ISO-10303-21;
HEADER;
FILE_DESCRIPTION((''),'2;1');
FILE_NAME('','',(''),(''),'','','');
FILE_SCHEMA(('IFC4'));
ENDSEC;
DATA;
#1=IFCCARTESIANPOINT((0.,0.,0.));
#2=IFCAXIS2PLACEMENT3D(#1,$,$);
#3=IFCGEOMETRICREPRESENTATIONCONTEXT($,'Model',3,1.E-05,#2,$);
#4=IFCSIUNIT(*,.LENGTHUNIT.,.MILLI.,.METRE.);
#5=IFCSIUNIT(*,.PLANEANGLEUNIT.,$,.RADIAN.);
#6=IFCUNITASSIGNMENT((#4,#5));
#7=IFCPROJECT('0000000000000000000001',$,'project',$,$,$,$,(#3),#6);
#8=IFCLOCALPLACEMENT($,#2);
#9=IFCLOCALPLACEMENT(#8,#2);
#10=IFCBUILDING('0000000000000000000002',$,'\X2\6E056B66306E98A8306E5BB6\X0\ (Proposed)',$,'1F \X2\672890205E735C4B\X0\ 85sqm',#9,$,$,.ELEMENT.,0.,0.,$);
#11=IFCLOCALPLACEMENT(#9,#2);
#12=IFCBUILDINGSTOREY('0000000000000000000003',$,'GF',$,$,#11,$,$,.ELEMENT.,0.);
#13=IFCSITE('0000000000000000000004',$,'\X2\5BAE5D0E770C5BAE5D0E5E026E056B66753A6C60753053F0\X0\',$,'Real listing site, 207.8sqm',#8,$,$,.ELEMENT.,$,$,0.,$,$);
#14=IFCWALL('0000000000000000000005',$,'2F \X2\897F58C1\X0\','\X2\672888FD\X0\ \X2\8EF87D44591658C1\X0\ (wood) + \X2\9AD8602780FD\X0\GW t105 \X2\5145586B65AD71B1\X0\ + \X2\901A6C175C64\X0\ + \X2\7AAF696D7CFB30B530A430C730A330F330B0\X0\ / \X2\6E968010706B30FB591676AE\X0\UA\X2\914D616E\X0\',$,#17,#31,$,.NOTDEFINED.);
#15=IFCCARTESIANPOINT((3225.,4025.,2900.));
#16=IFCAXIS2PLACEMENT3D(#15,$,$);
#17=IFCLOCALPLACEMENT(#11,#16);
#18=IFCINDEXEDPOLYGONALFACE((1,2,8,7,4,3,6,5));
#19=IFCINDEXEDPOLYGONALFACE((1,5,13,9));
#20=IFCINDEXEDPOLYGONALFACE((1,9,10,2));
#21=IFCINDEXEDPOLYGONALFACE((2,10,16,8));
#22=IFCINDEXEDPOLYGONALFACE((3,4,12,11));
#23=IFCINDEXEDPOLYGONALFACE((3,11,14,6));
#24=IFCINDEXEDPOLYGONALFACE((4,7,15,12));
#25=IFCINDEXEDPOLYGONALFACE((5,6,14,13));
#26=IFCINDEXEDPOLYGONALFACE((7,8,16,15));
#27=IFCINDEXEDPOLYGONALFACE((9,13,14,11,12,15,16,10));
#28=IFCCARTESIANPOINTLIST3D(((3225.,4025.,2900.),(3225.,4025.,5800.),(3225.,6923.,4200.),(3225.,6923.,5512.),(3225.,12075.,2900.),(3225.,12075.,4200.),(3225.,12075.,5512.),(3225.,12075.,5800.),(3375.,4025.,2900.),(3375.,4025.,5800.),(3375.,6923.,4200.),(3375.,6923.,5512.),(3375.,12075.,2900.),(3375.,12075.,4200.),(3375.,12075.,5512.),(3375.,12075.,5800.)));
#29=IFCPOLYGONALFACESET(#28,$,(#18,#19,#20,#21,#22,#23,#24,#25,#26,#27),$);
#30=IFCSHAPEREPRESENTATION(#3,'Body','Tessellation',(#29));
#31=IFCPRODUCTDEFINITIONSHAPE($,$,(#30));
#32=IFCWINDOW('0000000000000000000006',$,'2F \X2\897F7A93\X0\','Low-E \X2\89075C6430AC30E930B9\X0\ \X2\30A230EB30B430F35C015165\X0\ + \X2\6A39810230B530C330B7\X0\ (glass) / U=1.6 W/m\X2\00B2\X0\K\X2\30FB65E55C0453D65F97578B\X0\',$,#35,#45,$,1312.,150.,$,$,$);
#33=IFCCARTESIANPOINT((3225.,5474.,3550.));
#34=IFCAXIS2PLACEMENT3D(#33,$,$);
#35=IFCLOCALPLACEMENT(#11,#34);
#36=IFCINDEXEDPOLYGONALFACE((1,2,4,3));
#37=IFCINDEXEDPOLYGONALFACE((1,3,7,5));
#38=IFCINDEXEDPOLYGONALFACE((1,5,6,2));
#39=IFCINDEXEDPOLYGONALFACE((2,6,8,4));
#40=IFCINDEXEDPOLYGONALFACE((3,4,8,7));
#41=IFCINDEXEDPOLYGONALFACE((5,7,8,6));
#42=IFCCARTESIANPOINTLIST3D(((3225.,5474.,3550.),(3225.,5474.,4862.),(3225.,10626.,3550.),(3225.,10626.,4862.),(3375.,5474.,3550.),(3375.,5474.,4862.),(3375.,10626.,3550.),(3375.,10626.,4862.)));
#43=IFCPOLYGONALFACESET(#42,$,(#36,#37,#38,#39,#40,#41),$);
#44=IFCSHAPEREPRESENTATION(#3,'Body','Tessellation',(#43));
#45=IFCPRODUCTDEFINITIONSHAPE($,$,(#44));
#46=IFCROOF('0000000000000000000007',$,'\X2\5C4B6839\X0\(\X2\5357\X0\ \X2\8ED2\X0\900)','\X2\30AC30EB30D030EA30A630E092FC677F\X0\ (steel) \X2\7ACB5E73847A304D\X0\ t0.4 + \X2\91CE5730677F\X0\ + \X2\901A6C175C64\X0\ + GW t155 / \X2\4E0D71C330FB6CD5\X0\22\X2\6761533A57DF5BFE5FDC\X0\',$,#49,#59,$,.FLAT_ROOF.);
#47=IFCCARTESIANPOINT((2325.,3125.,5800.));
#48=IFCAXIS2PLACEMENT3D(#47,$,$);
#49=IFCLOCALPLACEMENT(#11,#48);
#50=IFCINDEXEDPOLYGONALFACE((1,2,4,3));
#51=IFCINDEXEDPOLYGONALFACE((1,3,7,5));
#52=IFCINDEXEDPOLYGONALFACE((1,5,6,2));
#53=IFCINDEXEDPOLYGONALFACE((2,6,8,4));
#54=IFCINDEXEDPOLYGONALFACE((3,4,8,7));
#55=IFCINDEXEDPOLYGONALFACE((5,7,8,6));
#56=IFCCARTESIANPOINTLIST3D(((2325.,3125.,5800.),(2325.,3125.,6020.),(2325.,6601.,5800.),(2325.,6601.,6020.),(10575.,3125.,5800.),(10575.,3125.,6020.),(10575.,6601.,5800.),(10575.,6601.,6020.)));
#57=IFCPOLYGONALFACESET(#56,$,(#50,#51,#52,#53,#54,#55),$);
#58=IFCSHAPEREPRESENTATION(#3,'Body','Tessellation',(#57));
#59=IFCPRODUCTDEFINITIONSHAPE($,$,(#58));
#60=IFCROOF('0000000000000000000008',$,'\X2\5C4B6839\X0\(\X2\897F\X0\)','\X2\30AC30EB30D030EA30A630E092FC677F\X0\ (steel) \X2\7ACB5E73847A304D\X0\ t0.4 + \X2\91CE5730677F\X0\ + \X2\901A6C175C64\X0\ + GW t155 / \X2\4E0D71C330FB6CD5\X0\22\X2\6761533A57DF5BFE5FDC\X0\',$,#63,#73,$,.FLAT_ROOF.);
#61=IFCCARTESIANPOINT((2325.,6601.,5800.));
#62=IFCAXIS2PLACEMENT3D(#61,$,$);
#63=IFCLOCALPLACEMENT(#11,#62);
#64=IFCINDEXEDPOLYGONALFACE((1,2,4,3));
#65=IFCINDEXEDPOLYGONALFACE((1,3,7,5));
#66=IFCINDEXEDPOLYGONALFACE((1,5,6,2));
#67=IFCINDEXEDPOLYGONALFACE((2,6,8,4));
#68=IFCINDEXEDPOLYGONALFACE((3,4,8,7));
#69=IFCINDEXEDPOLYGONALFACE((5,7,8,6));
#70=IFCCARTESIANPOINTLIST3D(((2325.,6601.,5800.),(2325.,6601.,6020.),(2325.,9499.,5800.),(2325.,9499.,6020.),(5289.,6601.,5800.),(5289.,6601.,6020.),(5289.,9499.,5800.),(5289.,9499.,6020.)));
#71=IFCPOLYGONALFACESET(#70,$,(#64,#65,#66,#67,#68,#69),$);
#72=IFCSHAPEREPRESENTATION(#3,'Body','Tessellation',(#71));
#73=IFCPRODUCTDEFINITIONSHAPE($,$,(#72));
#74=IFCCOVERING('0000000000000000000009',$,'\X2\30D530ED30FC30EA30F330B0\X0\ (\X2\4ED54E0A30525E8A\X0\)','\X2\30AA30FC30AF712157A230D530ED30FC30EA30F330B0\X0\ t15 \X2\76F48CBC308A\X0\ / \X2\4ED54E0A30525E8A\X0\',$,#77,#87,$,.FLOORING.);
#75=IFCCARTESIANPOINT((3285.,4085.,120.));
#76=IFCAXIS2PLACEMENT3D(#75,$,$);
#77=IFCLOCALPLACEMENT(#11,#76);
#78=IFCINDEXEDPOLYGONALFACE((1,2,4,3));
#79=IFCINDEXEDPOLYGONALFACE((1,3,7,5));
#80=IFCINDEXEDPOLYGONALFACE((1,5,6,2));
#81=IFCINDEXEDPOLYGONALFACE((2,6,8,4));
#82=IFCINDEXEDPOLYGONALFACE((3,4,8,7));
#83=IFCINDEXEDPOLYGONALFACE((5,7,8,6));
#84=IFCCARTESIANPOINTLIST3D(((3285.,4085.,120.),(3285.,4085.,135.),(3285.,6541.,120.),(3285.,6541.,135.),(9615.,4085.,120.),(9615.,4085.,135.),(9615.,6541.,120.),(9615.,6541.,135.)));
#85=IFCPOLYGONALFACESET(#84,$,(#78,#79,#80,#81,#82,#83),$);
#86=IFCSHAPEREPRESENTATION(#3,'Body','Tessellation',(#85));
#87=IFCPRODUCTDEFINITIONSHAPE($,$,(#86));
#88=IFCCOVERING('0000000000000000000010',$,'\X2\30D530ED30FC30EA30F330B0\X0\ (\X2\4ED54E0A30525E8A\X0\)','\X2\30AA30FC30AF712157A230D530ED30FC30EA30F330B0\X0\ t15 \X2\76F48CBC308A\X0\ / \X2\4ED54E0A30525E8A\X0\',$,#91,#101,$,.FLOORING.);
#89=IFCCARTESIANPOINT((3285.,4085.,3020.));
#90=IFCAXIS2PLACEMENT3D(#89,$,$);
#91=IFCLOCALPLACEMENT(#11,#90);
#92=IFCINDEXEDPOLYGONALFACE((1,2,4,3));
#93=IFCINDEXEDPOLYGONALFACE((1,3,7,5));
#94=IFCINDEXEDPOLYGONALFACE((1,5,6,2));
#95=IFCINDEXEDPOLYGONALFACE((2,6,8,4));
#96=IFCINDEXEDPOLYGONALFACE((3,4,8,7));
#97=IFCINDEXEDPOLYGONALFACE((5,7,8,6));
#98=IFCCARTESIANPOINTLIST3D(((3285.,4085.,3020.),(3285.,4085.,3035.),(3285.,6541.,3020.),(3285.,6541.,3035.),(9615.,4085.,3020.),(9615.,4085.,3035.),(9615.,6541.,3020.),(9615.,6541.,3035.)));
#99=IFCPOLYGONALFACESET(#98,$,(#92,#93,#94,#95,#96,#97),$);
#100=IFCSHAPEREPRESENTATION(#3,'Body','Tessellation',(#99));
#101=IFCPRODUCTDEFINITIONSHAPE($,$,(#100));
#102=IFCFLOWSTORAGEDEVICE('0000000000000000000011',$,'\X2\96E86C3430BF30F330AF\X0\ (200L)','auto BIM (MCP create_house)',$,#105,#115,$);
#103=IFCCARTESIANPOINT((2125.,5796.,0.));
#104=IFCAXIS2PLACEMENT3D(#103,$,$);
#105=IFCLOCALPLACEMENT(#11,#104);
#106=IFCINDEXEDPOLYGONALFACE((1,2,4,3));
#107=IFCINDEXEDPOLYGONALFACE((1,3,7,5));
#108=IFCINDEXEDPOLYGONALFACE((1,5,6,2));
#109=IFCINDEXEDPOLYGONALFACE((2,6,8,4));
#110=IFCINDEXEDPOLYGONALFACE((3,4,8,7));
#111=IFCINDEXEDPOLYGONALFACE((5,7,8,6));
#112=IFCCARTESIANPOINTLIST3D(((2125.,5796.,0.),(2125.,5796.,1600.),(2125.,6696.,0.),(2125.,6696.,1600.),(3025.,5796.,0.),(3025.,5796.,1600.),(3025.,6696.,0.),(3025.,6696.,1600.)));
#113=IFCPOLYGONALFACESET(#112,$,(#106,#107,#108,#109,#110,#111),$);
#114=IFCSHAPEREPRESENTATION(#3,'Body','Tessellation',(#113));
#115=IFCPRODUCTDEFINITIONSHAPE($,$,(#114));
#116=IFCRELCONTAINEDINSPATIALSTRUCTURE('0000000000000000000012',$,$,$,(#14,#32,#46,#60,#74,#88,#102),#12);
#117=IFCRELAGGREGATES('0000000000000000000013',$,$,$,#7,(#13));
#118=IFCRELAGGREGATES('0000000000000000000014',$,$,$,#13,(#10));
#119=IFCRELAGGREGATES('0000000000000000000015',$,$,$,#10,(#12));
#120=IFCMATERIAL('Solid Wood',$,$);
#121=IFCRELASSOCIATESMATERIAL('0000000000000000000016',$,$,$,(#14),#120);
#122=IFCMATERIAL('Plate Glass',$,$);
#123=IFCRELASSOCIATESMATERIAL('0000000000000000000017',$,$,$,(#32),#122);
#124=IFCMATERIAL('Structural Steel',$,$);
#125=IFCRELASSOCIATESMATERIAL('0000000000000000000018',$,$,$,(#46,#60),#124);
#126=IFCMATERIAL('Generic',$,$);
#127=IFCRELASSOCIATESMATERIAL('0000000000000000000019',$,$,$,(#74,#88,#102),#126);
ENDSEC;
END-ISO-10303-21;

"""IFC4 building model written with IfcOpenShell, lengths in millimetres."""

from ifc_helpers import new_model, si_unit, frame, frame_2d, origin, place, context, project, spatial, rectangle, extrude, material, element, fill, save


model = new_model("IFC4")

# Units and contexts
model_context = context("Model", 3, precision=1e-05, world=origin())
ifc_project = project(units=[si_unit("LENGTHUNIT", "METRE", prefix="MILLI"), si_unit("PLANEANGLEUNIT", "RADIAN")], contexts=[model_context])

# Site, building, storey
site_placement = place(None, origin())
site = spatial("IfcSite", under=ifc_project, at=site_placement, Name="宮崎県宮崎市清武町池田台", ObjectType="Real listing site, 207.8sqm", CompositionType="ELEMENT", RefElevation=0.0)
building_placement = place(site_placement, origin())
building = spatial("IfcBuilding", under=site, at=building_placement, Name="清武の風の家 (Proposed)", ObjectType="1F 木造平屋 85sqm", CompositionType="ELEMENT", ElevationOfRefHeight=0.0, ElevationOfTerrain=0.0)
storey_placement = place(building_placement, origin())
storey = spatial("IfcBuildingStorey", under=building, at=storey_placement, Name="GF", CompositionType="ELEMENT", Elevation=0.0)

# Shared definitions
ifc_material_1 = material(Name="Solid Wood")
ifc_material_2 = material(Name="Generic")

# Shared definitions
ifc_material_3 = material(Name="Plate Glass")

# Wall, opening, window
wall_1_placement = place(storey_placement, frame((3225.0, 4025.0, 2900.0)))
wall_1 = element("IfcWall", 1, at=wall_1_placement, inside=storey, material=ifc_material_1, Name="2F 西壁", Description="木製 軸組外壁 (wood) + 高性能GW t105 充填断熱 + 通気層 + 窯業系サイディング / 準耐火・外皮UA配慮", PredefinedType="NOTDEFINED", context=model_context, shape_type="SweptSolid", body=[
    extrude(rectangle(XDim=150.0, YDim=8050.0, at=frame_2d((75.0, 4025.0))), frame((3225.0, 4025.0, 2900.0)), (0.0, 0.0, 1.0), 2900.0),
])
opening_1_placement = place(storey_placement, frame((3225.0, 5474.0, 3550.0)))
opening_1 = element("IfcOpeningElement", 2, at=opening_1_placement, cuts=wall_1, PredefinedType="NOTDEFINED", context=model_context, shape_type="SweptSolid", body=[
    extrude(rectangle(XDim=150.0, YDim=5152.0, at=frame_2d((75.0, 2576.0))), frame((3225.0, 5474.0, 3550.0)), (0.0, 0.0, 1.0), 1312.0),
])
window_1_placement = place(storey_placement, frame((3225.0, 5474.0, 3550.0)))
window_1 = element("IfcWindow", 3, at=window_1_placement, inside=storey, material=ifc_material_3, Name="2F 西窓", Description="Low-E 複層ガラス アルゴン封入 + 樹脂サッシ (glass) / U=1.6 W/m²K・日射取得型", OverallHeight=1312.0, OverallWidth=150.0, context=model_context, shape_type="SweptSolid", body=[
    extrude(rectangle(XDim=150.0, YDim=5152.0, at=frame_2d((75.0, 2576.0))), frame((3225.0, 5474.0, 3550.0)), (0.0, 0.0, 1.0), 1312.0),
])
fill(opening_1, window_1)

# Roofs
ifc_material_4 = material(Name="Structural Steel")
roof_1_placement = place(storey_placement, frame((2325.0, 3125.0, 5800.0)))
element("IfcRoof", 4, at=roof_1_placement, inside=storey, material=ifc_material_4, Name="屋根(南 軒900)", Description="ガルバリウム鋼板 (steel) 立平葺き t0.4 + 野地板 + 通気層 + GW t155 / 不燃・法22条区域対応", PredefinedType="FLAT_ROOF", context=model_context, shape_type="SweptSolid", body=[
    extrude(rectangle(XDim=8250.0, YDim=3476.0, at=frame_2d((4125.0, 1738.0))), frame((2325.0, 3125.0, 5800.0)), (0.0, 0.0, 1.0), 220.0),
])
roof_2_placement = place(storey_placement, frame((2325.0, 6601.0, 5800.0)))
element("IfcRoof", 5, at=roof_2_placement, inside=storey, material=ifc_material_4, Name="屋根(西)", Description="ガルバリウム鋼板 (steel) 立平葺き t0.4 + 野地板 + 通気層 + GW t155 / 不燃・法22条区域対応", PredefinedType="FLAT_ROOF", context=model_context, shape_type="SweptSolid", body=[
    extrude(rectangle(XDim=2964.0, YDim=2898.0, at=frame_2d((1482.0, 1449.0))), frame((2325.0, 6601.0, 5800.0)), (0.0, 0.0, 1.0), 220.0),
])

# Coverings
covering_1_placement = place(storey_placement, frame((3285.0, 4085.0, 120.0)))
element("IfcCovering", 6, at=covering_1_placement, inside=storey, material=ifc_material_2, Name="フローリング (仕上げ床)", Description="オーク無垢フローリング t15 直貼り / 仕上げ床", PredefinedType="FLOORING", context=model_context, shape_type="SweptSolid", body=[
    extrude(rectangle(XDim=6330.0, YDim=2456.0, at=frame_2d((3165.0, 1228.0))), frame((3285.0, 4085.0, 120.0)), (0.0, 0.0, 1.0), 15.0),
])
covering_2_placement = place(storey_placement, frame((3285.0, 4085.0, 3020.0)))
element("IfcCovering", 7, at=covering_2_placement, inside=storey, material=ifc_material_2, Name="フローリング (仕上げ床)", Description="オーク無垢フローリング t15 直貼り / 仕上げ床", PredefinedType="FLOORING", context=model_context, shape_type="SweptSolid", body=[
    extrude(rectangle(XDim=6330.0, YDim=2456.0, at=frame_2d((3165.0, 1228.0))), frame((3285.0, 4085.0, 3020.0)), (0.0, 0.0, 1.0), 15.0),
])

# Flow storage device
flow_storage_device_placement = place(storey_placement, frame((2125.0, 5796.0, 0.0)))
element("IfcFlowStorageDevice", 8, at=flow_storage_device_placement, inside=storey, material=ifc_material_2, Name="雨水タンク (200L)", Description="auto BIM (MCP create_house)", context=model_context, shape_type="SweptSolid", body=[
    extrude(rectangle(XDim=900.0, YDim=900.0, at=frame_2d((450.0, 450.0))), frame((2125.0, 5796.0, 0.0)), (0.0, 0.0, 1.0), 1600.0),
])

save(model, "model.ifc")
